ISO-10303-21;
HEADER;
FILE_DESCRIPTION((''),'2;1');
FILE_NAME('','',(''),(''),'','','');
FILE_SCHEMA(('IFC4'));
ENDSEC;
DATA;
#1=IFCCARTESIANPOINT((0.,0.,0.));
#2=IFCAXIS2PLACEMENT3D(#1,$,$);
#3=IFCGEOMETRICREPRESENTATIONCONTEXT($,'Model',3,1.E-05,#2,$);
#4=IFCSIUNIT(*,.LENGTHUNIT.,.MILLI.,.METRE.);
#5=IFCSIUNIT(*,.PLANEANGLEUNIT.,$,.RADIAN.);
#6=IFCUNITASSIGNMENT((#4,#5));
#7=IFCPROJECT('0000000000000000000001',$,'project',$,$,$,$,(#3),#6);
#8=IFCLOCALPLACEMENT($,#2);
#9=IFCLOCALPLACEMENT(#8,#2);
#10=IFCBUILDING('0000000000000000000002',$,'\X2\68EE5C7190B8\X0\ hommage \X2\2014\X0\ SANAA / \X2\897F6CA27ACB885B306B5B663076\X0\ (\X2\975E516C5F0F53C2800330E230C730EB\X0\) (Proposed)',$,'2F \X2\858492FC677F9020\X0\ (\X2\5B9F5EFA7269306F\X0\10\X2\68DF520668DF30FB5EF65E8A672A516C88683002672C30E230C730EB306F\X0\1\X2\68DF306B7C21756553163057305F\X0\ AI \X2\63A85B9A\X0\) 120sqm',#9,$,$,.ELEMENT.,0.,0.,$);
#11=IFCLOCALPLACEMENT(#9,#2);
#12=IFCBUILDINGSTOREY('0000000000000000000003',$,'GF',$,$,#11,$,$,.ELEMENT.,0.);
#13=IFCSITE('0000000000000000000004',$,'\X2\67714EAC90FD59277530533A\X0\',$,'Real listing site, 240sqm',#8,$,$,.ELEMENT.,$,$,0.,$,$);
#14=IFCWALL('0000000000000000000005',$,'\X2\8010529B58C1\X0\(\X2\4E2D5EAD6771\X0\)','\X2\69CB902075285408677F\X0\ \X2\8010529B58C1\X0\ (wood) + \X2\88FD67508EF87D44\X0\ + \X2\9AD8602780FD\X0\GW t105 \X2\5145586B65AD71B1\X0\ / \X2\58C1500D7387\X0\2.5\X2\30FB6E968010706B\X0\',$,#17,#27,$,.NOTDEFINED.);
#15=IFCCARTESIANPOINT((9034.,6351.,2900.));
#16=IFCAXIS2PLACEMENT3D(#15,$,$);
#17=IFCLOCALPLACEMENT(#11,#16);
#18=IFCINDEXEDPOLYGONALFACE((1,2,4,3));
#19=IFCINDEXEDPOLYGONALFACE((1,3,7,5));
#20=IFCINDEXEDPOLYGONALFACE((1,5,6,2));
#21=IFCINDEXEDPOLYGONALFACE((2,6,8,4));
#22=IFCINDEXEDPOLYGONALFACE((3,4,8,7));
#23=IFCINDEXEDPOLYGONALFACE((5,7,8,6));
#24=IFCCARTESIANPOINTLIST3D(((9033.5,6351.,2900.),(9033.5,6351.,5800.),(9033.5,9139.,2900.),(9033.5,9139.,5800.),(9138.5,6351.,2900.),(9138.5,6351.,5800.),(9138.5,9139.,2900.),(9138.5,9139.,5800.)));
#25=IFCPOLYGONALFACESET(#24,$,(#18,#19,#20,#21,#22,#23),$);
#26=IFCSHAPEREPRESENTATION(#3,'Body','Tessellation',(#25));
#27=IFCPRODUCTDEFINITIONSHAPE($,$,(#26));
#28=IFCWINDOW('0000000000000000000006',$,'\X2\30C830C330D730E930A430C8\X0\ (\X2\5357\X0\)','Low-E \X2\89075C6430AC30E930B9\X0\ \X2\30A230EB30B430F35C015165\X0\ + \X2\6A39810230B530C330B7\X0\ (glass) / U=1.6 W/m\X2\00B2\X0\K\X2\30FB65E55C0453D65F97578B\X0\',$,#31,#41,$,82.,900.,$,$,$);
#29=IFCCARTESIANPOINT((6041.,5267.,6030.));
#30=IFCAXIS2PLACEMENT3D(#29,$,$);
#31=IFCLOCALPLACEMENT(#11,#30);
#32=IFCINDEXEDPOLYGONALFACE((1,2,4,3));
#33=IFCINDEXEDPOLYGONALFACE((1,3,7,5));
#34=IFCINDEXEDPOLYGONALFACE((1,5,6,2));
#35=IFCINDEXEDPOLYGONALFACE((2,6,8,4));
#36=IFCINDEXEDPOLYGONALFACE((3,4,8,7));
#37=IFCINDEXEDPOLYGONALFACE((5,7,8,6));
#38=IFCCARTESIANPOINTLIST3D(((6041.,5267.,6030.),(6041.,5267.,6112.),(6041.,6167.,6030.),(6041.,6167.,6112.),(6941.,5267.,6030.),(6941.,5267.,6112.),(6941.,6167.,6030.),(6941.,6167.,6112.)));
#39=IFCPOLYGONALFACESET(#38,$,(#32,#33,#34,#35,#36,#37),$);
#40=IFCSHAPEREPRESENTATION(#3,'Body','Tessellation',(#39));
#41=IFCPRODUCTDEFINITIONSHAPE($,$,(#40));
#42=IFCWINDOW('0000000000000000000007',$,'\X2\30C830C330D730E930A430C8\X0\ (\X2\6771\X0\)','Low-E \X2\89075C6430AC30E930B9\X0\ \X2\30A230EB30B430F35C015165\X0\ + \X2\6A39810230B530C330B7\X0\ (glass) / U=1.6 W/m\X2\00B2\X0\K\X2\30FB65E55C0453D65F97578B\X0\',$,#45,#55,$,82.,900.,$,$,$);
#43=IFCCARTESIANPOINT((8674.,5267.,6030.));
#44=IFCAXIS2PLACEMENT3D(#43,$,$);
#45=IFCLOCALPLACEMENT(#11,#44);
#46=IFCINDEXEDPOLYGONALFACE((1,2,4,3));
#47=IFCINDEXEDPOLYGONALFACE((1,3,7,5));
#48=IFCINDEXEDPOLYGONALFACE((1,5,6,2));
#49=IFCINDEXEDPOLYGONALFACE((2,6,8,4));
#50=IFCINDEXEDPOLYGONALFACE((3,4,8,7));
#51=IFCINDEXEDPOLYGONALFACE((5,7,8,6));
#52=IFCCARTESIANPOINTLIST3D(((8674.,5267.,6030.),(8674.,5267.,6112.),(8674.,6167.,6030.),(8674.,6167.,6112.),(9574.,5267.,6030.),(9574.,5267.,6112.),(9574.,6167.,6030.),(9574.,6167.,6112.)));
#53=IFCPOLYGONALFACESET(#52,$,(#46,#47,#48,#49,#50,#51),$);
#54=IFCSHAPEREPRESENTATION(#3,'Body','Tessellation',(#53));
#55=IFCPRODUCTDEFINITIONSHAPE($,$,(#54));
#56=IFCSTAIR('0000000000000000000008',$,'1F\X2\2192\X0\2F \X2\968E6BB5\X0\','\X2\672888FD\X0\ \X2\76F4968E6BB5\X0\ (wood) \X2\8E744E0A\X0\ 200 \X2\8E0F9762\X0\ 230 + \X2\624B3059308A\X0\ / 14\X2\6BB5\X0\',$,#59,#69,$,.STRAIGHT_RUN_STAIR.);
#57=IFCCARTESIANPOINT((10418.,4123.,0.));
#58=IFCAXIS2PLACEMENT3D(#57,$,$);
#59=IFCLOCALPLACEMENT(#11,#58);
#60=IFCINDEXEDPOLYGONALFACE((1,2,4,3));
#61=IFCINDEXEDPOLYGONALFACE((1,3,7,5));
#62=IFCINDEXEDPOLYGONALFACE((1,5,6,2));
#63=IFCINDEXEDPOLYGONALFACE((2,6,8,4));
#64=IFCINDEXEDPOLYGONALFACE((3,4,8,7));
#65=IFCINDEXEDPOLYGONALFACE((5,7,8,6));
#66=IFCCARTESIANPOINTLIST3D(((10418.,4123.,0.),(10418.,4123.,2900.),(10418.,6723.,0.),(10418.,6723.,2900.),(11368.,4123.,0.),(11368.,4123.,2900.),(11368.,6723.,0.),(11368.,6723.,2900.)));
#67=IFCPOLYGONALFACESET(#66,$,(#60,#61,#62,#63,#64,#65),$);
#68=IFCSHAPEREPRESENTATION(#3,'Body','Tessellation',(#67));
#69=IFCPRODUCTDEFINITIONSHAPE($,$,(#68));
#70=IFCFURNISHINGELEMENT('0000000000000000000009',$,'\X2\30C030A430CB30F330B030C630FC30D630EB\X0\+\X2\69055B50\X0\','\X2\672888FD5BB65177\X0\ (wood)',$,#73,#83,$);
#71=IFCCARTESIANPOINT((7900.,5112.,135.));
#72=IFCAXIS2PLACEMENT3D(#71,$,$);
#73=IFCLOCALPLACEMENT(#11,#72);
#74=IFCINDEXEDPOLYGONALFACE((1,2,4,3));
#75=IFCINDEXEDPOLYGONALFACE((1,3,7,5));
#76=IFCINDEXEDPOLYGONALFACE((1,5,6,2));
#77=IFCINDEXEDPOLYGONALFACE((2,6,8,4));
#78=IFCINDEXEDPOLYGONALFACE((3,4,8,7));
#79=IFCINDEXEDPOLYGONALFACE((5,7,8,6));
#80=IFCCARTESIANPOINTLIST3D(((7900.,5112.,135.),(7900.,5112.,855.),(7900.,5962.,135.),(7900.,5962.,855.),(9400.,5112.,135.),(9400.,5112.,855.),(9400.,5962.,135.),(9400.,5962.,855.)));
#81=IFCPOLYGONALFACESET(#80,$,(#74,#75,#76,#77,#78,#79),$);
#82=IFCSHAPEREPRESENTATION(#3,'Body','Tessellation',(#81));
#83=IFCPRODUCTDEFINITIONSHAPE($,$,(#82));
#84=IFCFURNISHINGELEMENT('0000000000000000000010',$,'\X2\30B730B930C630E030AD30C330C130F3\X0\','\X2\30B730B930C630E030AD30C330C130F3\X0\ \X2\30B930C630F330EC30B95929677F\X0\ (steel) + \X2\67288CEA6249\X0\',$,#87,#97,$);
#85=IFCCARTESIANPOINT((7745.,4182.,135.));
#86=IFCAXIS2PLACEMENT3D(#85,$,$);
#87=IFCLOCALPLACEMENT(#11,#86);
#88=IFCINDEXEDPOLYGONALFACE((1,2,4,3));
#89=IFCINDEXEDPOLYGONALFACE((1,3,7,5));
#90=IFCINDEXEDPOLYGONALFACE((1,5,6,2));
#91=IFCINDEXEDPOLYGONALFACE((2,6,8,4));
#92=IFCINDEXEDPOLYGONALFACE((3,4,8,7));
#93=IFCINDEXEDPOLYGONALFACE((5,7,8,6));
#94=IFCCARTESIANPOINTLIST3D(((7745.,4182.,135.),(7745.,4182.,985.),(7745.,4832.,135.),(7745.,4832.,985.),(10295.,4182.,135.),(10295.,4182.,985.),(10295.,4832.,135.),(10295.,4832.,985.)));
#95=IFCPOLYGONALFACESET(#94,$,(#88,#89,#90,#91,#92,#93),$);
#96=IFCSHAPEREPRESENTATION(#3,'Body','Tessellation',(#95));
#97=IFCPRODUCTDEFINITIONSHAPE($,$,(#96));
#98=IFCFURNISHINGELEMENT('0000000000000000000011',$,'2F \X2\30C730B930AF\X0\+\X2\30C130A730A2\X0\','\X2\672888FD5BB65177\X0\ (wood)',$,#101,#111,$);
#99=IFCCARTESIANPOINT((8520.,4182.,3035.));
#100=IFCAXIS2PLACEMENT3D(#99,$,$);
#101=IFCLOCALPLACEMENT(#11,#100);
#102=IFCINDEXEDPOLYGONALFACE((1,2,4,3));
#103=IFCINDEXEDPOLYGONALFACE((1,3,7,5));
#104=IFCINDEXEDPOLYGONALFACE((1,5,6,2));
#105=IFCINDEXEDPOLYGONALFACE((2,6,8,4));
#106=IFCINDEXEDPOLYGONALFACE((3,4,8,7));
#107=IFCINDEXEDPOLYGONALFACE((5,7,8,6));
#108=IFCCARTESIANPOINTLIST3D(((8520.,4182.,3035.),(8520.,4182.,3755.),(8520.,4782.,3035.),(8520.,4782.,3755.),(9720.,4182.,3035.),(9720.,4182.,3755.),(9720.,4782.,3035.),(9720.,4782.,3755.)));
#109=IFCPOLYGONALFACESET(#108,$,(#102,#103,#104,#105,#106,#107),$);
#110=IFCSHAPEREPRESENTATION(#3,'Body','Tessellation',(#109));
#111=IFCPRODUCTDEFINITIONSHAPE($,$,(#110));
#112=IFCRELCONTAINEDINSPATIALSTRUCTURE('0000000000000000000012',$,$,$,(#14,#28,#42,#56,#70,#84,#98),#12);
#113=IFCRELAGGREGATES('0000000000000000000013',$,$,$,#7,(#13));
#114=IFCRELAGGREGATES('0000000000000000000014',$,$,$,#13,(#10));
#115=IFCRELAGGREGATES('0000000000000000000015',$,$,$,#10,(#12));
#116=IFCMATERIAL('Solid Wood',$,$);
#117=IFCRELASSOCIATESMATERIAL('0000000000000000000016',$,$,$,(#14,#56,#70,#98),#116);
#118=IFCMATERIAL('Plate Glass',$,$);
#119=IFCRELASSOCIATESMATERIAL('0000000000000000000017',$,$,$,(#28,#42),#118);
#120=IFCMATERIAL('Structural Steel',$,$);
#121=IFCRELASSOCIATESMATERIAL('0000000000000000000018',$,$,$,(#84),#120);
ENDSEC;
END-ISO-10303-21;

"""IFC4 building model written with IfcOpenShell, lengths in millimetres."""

from ifc_helpers import new_model, si_unit, frame, frame_2d, origin, place, context, project, spatial, rectangle, extrude, material, element, save


model = new_model("IFC4")

# Units and contexts
model_context = context("Model", 3, precision=1e-05, world=origin())
ifc_project = project(units=[si_unit("LENGTHUNIT", "METRE", prefix="MILLI"), si_unit("PLANEANGLEUNIT", "RADIAN")], contexts=[model_context])

# Site, building, storey
site_placement = place(None, origin())
site = spatial("IfcSite", under=ifc_project, at=site_placement, Name="東京都大田区", ObjectType="Real listing site, 240sqm", CompositionType="ELEMENT", RefElevation=0.0)
building_placement = place(site_placement, origin())
building = spatial("IfcBuilding", under=site, at=building_placement, Name="森山邸 hommage — SANAA / 西沢立衛に学ぶ (非公式参考モデル) (Proposed)", ObjectType="2F 薄鋼板造 (実建物は10棟分棟・延床未公表。本モデルは1棟に簡略化した AI 推定) 120sqm", CompositionType="ELEMENT", ElevationOfRefHeight=0.0, ElevationOfTerrain=0.0)
storey_placement = place(building_placement, origin())
storey = spatial("IfcBuildingStorey", under=building, at=storey_placement, Name="GF", CompositionType="ELEMENT", Elevation=0.0)

# Shared definitions
ifc_material_1 = material(Name="Solid Wood")

# Shared definitions
ifc_material_2 = material(Name="Plate Glass")

# Wall
wall_1_placement = place(storey_placement, frame((9034.0, 6351.0, 2900.0)))
element("IfcWall", 1, at=wall_1_placement, inside=storey, material=ifc_material_1, Name="耐力壁(中庭東)", Description="構造用合板 耐力壁 (wood) + 製材軸組 + 高性能GW t105 充填断熱 / 壁倍率2.5・準耐火", PredefinedType="NOTDEFINED", context=model_context, shape_type="SweptSolid", body=[
    extrude(rectangle(XDim=105.0, YDim=2788.0, at=frame_2d((52.0, 1394.0))), frame((9034.0, 6351.0, 2900.0)), (0.0, 0.0, 1.0), 2900.0),
])

# Windows
window_1_placement = place(storey_placement, frame((6041.0, 5267.0, 6030.0)))
element("IfcWindow", 2, at=window_1_placement, inside=storey, material=ifc_material_2, Name="トップライト (南)", Description="Low-E 複層ガラス アルゴン封入 + 樹脂サッシ (glass) / U=1.6 W/m²K・日射取得型", OverallHeight=82.0, OverallWidth=900.0, context=model_context, shape_type="SweptSolid", body=[
    extrude(rectangle(XDim=900.0, YDim=900.0, at=frame_2d((450.0, 450.0))), frame((6041.0, 5267.0, 6030.0)), (0.0, 0.0, 1.0), 82.0),
])
window_2_placement = place(storey_placement, frame((8674.0, 5267.0, 6030.0)))
element("IfcWindow", 3, at=window_2_placement, inside=storey, material=ifc_material_2, Name="トップライト (東)", Description="Low-E 複層ガラス アルゴン封入 + 樹脂サッシ (glass) / U=1.6 W/m²K・日射取得型", OverallHeight=82.0, OverallWidth=900.0, context=model_context, shape_type="SweptSolid", body=[
    extrude(rectangle(XDim=900.0, YDim=900.0, at=frame_2d((450.0, 450.0))), frame((8674.0, 5267.0, 6030.0)), (0.0, 0.0, 1.0), 82.0),
])

# Stair
stair_placement = place(storey_placement, frame((10418.0, 4123.0, 0.0)))
element("IfcStair", 4, at=stair_placement, inside=storey, material=ifc_material_1, Name="1F→2F 階段", Description="木製 直階段 (wood) 蹴上 200 踏面 230 + 手すり / 14段", PredefinedType="STRAIGHT_RUN_STAIR", context=model_context, shape_type="SweptSolid", body=[
    extrude(rectangle(XDim=950.0, YDim=2600.0, at=frame_2d((475.0, 1300.0))), frame((10418.0, 4123.0, 0.0)), (0.0, 0.0, 1.0), 2900.0),
])

# Furnishing elements
furnishing_1_placement = place(storey_placement, frame((7900.0, 5112.0, 135.0)))
element("IfcFurnishingElement", 5, at=furnishing_1_placement, inside=storey, material=ifc_material_1, Name="ダイニングテーブル+椅子", Description="木製家具 (wood)", context=model_context, shape_type="SweptSolid", body=[
    extrude(rectangle(XDim=1500.0, YDim=850.0, at=frame_2d((750.0, 425.0))), frame((7900.0, 5112.0, 135.0)), (0.0, 0.0, 1.0), 720.0),
])
ifc_material_3 = material(Name="Structural Steel")
furnishing_2_placement = place(storey_placement, frame((7745.0, 4182.0, 135.0)))
element("IfcFurnishingElement", 6, at=furnishing_2_placement, inside=storey, material=ifc_material_3, Name="システムキッチン", Description="システムキッチン ステンレス天板 (steel) + 木質扉", context=model_context, shape_type="SweptSolid", body=[
    extrude(rectangle(XDim=2550.0, YDim=650.0, at=frame_2d((1275.0, 325.0))), frame((7745.0, 4182.0, 135.0)), (0.0, 0.0, 1.0), 850.0),
])
furnishing_3_placement = place(storey_placement, frame((8520.0, 4182.0, 3035.0)))
element("IfcFurnishingElement", 7, at=furnishing_3_placement, inside=storey, material=ifc_material_1, Name="2F デスク+チェア", Description="木製家具 (wood)", context=model_context, shape_type="SweptSolid", body=[
    extrude(rectangle(XDim=1200.0, YDim=600.0, at=frame_2d((600.0, 300.0))), frame((8520.0, 4182.0, 3035.0)), (0.0, 0.0, 1.0), 720.0),
])

save(model, "model.ifc")
